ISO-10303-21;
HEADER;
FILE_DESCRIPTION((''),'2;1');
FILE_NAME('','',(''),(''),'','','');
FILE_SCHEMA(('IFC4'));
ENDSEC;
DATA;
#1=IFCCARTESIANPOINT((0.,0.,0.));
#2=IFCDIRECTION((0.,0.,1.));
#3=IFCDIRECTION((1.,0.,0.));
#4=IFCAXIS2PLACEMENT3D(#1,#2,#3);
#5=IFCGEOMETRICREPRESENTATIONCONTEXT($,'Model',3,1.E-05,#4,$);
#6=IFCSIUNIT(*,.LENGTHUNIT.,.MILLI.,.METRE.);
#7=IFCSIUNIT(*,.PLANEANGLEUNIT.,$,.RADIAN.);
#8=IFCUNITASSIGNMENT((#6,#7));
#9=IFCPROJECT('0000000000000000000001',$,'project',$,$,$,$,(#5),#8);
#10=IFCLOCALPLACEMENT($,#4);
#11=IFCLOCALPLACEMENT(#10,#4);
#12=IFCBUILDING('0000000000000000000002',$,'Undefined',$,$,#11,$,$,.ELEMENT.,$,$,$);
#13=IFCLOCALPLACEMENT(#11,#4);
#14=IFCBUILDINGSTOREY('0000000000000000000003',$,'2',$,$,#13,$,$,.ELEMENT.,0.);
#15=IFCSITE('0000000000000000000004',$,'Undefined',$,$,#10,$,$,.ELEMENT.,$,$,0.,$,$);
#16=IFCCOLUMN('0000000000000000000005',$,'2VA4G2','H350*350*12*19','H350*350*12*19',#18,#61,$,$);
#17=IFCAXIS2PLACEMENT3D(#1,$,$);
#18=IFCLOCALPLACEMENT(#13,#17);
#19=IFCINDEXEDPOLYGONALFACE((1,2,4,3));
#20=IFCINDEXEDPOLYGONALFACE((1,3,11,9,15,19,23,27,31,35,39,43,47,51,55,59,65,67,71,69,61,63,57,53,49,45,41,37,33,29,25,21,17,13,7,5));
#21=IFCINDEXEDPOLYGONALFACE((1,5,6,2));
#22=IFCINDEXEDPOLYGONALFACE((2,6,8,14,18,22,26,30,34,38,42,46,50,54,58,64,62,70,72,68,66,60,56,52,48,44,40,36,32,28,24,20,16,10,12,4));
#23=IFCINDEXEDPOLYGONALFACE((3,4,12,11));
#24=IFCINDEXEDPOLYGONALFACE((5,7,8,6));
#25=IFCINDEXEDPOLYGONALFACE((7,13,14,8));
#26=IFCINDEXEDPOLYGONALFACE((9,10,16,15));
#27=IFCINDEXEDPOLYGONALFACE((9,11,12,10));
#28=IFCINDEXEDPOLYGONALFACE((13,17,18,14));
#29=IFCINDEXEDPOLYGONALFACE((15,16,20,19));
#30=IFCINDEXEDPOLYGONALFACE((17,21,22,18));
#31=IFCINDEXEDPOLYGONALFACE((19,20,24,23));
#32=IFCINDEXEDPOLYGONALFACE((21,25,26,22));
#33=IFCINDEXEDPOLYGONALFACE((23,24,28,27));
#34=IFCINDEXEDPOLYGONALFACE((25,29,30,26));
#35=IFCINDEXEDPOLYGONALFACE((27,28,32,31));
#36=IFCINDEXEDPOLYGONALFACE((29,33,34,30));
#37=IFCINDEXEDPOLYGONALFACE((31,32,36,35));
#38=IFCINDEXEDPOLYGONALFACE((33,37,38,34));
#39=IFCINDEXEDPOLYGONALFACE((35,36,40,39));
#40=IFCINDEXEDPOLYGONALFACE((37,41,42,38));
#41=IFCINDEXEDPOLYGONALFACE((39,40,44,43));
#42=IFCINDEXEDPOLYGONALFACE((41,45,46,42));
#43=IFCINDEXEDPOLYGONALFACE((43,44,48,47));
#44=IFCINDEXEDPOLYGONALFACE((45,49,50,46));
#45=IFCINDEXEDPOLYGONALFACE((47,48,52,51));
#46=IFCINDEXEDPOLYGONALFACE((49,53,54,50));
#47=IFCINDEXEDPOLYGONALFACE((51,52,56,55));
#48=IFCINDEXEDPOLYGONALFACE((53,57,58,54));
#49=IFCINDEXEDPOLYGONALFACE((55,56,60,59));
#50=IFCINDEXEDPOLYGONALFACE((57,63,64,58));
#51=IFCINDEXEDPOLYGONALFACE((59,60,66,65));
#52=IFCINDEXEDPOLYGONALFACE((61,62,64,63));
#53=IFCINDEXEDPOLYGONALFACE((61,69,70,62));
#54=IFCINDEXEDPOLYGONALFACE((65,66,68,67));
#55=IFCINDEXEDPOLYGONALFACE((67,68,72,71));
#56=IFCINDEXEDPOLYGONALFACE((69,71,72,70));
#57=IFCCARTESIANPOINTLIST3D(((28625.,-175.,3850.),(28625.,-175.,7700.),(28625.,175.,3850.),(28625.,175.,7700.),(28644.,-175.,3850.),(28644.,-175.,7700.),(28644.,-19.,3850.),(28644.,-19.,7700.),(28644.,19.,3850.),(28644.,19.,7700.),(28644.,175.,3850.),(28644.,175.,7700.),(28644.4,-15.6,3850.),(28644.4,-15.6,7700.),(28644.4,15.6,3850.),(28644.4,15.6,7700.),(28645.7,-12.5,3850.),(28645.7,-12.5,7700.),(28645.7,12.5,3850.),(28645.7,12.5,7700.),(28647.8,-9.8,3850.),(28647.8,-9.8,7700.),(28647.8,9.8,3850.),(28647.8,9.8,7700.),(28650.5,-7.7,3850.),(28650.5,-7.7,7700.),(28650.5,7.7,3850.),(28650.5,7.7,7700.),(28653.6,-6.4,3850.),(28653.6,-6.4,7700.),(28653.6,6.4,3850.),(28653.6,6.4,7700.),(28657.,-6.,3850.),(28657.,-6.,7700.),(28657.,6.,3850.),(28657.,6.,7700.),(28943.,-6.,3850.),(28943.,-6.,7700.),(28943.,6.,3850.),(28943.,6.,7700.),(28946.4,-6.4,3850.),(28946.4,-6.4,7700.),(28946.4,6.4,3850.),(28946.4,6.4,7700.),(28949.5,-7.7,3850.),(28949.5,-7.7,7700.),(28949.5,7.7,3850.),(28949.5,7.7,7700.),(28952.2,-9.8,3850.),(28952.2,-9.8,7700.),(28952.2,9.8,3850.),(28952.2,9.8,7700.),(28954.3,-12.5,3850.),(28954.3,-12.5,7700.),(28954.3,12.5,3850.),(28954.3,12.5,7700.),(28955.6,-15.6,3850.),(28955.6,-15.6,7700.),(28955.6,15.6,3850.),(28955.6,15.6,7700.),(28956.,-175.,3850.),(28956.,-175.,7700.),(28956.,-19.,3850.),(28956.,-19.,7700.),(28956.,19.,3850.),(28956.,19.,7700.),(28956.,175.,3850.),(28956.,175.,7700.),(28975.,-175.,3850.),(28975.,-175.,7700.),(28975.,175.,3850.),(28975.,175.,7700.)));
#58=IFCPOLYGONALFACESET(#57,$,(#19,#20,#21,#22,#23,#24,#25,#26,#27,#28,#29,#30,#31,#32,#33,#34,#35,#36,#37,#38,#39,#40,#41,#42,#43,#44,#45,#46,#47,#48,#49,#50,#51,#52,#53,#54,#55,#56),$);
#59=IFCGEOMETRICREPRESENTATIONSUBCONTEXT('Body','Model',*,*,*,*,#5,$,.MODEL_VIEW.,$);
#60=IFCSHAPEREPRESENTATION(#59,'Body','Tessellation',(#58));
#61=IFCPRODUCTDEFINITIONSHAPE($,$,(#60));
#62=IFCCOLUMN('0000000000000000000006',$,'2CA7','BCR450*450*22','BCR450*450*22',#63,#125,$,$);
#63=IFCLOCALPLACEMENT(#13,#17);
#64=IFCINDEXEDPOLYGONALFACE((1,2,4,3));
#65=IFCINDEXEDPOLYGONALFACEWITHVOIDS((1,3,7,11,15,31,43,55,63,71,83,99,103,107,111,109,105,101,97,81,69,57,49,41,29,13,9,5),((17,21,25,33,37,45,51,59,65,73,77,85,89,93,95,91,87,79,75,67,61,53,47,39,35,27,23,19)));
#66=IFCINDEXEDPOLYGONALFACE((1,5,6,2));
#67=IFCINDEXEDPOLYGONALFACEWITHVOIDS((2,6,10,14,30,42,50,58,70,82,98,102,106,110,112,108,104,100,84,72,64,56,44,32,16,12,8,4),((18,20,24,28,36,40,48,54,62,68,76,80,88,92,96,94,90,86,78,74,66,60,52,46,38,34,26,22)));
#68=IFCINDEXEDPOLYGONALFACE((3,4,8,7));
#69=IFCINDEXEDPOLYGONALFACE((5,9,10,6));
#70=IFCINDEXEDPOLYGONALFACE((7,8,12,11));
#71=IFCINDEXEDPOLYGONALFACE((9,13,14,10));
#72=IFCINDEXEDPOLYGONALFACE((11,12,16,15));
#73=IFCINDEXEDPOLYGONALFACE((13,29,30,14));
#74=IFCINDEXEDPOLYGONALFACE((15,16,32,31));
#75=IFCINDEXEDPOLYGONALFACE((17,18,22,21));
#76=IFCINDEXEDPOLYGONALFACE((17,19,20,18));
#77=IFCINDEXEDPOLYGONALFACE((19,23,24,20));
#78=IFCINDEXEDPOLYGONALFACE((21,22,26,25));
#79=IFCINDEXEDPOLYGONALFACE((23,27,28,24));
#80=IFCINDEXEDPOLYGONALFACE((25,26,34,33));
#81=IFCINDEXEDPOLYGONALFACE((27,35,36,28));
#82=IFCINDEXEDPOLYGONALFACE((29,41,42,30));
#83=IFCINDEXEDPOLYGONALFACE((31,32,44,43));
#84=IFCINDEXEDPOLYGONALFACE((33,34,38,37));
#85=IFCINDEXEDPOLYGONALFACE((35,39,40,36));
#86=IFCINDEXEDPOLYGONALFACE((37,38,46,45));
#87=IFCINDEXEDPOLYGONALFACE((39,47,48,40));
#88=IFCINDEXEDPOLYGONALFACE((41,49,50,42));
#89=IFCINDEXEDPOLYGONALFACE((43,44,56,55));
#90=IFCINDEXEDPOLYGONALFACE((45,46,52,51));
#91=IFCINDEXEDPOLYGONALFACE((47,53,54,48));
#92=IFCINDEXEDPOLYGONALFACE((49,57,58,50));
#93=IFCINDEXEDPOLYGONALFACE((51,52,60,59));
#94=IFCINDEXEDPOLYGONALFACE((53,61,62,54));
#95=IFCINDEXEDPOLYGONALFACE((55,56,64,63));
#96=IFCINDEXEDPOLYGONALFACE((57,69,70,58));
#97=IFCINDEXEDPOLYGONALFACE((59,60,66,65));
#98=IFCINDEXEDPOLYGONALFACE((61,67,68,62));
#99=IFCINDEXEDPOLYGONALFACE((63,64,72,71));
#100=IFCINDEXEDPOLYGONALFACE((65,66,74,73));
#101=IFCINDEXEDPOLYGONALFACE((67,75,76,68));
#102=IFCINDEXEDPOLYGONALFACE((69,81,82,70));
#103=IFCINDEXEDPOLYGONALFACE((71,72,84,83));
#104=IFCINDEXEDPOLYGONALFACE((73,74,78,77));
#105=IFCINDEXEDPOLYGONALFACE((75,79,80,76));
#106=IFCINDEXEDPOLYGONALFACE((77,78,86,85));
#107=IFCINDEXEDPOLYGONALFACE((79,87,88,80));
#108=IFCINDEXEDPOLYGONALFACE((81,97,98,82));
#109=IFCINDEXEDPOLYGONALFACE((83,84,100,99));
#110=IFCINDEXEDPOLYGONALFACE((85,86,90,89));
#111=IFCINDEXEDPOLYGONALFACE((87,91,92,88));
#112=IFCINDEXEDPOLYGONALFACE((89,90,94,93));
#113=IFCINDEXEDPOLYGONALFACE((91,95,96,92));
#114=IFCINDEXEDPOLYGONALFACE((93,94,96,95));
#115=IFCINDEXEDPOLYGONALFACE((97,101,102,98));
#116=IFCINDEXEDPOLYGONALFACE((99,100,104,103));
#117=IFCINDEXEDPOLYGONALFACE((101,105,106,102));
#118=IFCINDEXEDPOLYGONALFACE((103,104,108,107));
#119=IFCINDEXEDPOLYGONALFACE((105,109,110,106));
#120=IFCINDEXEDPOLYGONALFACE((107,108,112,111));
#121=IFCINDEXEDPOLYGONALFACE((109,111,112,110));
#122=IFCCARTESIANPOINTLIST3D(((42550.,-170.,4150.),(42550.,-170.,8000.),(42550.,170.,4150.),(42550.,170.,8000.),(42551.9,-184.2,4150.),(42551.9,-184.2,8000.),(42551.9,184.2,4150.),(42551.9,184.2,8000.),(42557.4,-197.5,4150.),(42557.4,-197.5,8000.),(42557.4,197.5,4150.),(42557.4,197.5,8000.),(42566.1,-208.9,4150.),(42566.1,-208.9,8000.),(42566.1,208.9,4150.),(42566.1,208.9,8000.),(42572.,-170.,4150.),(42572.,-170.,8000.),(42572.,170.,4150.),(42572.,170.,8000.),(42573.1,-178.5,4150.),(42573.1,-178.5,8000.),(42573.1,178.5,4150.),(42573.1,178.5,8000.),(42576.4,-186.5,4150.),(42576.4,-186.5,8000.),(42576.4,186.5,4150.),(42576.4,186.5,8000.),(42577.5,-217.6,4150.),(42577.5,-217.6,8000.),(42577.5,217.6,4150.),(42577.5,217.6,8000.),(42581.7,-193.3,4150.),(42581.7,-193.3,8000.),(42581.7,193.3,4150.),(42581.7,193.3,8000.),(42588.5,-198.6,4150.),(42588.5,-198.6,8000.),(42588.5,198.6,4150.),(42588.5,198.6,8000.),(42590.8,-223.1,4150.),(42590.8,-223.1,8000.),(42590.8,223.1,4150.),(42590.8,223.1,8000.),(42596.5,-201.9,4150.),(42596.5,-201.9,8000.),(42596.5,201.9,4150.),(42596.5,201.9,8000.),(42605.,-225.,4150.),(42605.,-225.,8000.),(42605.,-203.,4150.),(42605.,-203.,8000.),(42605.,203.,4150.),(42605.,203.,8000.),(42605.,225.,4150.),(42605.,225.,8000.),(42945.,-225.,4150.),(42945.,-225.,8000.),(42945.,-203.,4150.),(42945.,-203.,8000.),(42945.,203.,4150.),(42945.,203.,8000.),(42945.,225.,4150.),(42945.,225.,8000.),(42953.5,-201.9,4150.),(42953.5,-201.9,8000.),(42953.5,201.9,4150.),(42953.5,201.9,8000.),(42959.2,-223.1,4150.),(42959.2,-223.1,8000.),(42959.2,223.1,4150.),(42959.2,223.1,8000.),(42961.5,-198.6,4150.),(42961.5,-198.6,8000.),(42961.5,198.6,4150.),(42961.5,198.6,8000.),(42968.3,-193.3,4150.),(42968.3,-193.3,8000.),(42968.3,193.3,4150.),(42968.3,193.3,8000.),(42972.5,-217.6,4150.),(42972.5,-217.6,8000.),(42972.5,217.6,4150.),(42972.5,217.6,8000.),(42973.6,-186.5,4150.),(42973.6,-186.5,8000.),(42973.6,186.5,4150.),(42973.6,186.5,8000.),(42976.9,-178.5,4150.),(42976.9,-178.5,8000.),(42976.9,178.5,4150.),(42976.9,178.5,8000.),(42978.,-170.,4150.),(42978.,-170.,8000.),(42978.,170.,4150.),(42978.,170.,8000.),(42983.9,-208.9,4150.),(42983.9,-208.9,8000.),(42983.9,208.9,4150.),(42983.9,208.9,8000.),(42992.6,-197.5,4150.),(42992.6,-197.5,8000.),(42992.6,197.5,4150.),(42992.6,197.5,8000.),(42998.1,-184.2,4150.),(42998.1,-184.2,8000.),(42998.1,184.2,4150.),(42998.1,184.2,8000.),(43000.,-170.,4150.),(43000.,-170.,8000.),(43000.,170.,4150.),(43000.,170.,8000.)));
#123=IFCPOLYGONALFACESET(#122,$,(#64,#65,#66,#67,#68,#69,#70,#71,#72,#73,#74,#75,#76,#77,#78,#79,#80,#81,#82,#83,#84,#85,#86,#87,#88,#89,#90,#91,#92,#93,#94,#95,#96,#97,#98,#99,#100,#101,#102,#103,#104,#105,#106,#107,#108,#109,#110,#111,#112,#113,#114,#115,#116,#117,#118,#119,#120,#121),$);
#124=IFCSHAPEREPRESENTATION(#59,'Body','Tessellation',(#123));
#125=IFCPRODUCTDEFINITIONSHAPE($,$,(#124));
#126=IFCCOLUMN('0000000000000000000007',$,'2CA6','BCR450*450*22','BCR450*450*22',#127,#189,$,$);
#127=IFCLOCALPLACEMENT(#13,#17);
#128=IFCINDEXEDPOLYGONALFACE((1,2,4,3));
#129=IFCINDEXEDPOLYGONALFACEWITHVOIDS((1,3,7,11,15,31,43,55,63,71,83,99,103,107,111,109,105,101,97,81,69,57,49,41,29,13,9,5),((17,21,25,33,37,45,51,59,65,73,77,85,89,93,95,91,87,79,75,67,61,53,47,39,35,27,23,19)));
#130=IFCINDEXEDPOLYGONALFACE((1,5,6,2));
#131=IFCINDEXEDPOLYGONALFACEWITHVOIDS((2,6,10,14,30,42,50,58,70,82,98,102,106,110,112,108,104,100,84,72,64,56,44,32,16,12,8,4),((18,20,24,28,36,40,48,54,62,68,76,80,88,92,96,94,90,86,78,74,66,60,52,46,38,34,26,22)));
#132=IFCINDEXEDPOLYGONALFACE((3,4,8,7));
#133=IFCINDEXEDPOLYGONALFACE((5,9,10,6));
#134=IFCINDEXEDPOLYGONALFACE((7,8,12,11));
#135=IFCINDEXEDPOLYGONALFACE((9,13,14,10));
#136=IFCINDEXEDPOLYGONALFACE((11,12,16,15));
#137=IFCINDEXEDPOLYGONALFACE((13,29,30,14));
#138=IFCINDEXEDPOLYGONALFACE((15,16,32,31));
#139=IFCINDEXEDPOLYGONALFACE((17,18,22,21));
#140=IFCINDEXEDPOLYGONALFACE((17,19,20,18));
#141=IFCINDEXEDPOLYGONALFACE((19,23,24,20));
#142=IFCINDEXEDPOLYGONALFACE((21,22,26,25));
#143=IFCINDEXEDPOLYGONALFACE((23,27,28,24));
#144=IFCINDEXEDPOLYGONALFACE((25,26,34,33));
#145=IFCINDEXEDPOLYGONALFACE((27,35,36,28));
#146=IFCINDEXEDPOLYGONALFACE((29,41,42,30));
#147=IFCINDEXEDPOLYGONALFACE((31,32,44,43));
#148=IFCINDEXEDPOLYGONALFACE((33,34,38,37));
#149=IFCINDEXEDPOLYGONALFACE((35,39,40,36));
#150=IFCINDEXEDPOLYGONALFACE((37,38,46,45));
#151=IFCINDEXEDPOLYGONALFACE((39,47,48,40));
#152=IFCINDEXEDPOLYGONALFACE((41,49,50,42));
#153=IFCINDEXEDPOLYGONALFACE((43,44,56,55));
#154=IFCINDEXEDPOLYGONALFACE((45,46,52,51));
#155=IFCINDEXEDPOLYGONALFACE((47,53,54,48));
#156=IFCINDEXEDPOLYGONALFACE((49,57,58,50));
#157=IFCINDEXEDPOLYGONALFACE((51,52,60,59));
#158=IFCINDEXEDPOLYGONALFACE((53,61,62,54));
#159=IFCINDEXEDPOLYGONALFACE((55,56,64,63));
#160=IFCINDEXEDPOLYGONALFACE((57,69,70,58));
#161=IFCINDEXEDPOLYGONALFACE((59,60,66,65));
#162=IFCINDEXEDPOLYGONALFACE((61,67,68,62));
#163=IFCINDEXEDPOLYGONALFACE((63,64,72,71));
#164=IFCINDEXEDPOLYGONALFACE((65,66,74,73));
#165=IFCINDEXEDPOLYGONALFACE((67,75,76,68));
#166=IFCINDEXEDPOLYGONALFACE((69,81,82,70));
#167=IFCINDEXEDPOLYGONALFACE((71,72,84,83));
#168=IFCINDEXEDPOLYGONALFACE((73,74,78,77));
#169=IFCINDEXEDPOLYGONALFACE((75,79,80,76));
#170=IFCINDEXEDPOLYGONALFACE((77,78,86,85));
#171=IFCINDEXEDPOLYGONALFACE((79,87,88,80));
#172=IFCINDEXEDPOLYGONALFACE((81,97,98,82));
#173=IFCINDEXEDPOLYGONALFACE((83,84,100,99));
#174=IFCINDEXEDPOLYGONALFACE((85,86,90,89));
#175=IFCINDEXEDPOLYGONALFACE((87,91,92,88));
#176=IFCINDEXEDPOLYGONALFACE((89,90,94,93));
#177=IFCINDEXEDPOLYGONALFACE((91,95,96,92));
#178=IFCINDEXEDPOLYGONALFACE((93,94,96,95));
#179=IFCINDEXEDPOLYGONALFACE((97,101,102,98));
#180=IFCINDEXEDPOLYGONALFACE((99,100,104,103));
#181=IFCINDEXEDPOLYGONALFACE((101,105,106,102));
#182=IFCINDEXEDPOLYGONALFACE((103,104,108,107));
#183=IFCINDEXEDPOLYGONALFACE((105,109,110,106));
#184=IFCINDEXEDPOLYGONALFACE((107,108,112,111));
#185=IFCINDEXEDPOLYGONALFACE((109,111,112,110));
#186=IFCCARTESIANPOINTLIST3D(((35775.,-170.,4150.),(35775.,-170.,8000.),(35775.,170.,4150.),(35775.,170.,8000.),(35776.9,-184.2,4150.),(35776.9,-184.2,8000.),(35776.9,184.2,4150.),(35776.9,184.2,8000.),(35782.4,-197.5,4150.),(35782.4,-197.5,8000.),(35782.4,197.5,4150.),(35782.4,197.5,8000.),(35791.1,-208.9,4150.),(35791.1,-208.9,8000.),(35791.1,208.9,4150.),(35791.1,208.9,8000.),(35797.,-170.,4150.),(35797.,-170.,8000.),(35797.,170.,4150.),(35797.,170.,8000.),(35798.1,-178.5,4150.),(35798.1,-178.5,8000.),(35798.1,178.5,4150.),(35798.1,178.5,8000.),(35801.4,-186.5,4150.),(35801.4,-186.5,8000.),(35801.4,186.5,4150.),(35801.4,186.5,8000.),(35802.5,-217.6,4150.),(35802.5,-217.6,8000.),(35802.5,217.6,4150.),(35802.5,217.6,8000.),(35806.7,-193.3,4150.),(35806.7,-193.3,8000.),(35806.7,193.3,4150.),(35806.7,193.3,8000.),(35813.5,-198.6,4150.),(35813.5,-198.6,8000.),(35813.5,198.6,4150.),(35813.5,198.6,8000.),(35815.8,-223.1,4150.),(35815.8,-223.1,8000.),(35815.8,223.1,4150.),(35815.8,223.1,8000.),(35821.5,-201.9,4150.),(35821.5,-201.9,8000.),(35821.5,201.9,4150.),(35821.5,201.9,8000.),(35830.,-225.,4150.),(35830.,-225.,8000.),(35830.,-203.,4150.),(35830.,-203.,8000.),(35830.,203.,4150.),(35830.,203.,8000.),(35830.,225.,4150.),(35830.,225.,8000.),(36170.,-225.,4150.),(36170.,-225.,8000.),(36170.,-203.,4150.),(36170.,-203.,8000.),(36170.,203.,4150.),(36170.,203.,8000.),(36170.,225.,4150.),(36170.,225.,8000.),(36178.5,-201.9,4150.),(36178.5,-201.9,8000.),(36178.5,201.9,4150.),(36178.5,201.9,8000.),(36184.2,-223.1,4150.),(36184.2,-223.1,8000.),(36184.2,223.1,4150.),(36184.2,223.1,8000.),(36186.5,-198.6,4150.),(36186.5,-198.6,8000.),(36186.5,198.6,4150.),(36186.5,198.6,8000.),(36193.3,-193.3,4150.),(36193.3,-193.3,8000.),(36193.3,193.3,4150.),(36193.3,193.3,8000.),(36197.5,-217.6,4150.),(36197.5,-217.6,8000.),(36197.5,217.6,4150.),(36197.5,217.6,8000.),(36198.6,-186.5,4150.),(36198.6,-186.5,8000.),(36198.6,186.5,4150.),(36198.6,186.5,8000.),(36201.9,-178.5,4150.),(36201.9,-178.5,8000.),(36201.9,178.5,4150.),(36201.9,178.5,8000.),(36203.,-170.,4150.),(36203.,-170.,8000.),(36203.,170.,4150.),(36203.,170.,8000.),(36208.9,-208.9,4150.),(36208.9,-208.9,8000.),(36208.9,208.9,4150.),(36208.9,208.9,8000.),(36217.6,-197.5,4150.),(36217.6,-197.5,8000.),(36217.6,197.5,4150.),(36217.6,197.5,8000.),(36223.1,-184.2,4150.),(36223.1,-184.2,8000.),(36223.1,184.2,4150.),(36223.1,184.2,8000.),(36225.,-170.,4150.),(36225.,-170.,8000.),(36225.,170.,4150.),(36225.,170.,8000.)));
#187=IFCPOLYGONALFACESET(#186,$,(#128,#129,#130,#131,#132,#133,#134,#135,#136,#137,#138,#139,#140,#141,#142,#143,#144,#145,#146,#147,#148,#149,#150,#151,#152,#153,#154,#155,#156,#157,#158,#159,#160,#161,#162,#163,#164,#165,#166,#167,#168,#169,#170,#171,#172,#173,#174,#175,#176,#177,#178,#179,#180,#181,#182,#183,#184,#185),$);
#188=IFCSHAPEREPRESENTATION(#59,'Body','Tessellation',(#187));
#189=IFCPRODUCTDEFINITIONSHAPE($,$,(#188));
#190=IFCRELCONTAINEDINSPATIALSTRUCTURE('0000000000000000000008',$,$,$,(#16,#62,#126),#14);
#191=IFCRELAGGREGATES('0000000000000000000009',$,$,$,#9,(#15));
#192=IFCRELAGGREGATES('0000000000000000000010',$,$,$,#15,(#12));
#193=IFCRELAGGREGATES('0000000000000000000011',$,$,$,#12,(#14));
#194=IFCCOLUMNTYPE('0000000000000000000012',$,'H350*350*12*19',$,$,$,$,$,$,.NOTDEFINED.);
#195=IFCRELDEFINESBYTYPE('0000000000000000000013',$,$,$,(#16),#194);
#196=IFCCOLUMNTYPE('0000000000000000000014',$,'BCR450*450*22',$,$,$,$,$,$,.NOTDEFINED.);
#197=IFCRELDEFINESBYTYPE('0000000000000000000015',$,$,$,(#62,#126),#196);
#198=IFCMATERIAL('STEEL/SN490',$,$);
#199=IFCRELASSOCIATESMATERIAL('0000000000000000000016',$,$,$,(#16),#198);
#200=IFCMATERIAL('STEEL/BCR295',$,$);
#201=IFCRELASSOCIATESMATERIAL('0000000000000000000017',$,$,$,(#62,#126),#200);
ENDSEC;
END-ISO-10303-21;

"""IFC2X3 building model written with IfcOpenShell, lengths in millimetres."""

from ifc_helpers import new_model, si_unit, frame, origin_with_axes, origin_2d_with_axis, place, context, subcontext, project, spatial, hollow_rectangle, i_section, extrude, material, type_object, element, save


model = new_model("IFC2X3")

# Units and contexts
model_context = context("Model", 3, precision=1e-05, world=origin_with_axes())
body_context = subcontext(model_context, "Body", "Model", "MODEL_VIEW")
ifc_project = project(units=[si_unit("LENGTHUNIT", "METRE", prefix="MILLI"), si_unit("PLANEANGLEUNIT", "RADIAN")], contexts=[model_context])

# Site, building, storey
site_placement = place(None, origin_with_axes())
site = spatial("IfcSite", under=ifc_project, at=site_placement, Name="Undefined", CompositionType="ELEMENT", RefElevation=0.0)
building_placement = place(site_placement, origin_with_axes())
building = spatial("IfcBuilding", under=site, at=building_placement, Name="Undefined", CompositionType="ELEMENT")
storey_placement = place(building_placement, origin_with_axes())
storey = spatial("IfcBuildingStorey", under=building, at=storey_placement, Name="2", CompositionType="ELEMENT", Elevation=0.0)

# Columns
ifc_material_1 = material(Name="STEEL/SN490")
column_type_1 = type_object("IfcColumnType", Name="H350*350*12*19", PredefinedType="NOTDEFINED")
column_placement = place(storey_placement, frame((28800.0, 0.0, 3850.0), z_axis=(0.0, 0.0, 1.0), x_axis=(-1.0, 0.0, 0.0)))
element("IfcColumn", 1, at=column_placement, inside=storey, type_object=column_type_1, material=ifc_material_1, Name="2VA4G2", Description="H350*350*12*19", ObjectType="H350*350*12*19", context=body_context, shape_type="SweptSolid", body=[
    extrude(i_section(OverallWidth=350.0, OverallDepth=350.0, WebThickness=12.0, FlangeThickness=19.0, FilletRadius=13.0, at=origin_2d_with_axis()), frame((0.0, 0.0, 3850.0), z_axis=(0.0, 0.0, -1.0), x_axis=(0.0, 1.0, 0.0)), (0.0, 0.0, 1.0), 3850.0),
])
ifc_material_2 = material(Name="STEEL/BCR295")
column_type_2 = type_object("IfcColumnType", Name="BCR450*450*22", PredefinedType="NOTDEFINED")
for number, where, z_axis, x_axis, name in (
    (2, (42775.0, 0.0, 4150.0), (0.0, 0.0, 1.0), (0.0, 1.0, 0.0), "2CA7"),
    (3, (36000.0, 0.0, 4150.0), (0.0, 0.0, 1.0), (0.0, 1.0, 0.0), "2CA6"),
):
    element("IfcColumn", number, at=place(storey_placement, frame(where, z_axis=z_axis, x_axis=x_axis)), inside=storey, type_object=column_type_2, material=ifc_material_2, Name=name, Description="BCR450*450*22", ObjectType="BCR450*450*22", context=body_context, shape_type="SweptSolid", body=[
        extrude(hollow_rectangle(XDim=450.0, YDim=450.0, WallThickness=22.0, InnerFilletRadius=33.0, OuterFilletRadius=55.0, at=origin_2d_with_axis()), frame((0.0, 0.0, 3850.0), z_axis=(0.0, 0.0, -1.0), x_axis=(0.0, 1.0, 0.0)), (0.0, 0.0, 1.0), 3850.0),
    ])

save(model, "model.ifc")
